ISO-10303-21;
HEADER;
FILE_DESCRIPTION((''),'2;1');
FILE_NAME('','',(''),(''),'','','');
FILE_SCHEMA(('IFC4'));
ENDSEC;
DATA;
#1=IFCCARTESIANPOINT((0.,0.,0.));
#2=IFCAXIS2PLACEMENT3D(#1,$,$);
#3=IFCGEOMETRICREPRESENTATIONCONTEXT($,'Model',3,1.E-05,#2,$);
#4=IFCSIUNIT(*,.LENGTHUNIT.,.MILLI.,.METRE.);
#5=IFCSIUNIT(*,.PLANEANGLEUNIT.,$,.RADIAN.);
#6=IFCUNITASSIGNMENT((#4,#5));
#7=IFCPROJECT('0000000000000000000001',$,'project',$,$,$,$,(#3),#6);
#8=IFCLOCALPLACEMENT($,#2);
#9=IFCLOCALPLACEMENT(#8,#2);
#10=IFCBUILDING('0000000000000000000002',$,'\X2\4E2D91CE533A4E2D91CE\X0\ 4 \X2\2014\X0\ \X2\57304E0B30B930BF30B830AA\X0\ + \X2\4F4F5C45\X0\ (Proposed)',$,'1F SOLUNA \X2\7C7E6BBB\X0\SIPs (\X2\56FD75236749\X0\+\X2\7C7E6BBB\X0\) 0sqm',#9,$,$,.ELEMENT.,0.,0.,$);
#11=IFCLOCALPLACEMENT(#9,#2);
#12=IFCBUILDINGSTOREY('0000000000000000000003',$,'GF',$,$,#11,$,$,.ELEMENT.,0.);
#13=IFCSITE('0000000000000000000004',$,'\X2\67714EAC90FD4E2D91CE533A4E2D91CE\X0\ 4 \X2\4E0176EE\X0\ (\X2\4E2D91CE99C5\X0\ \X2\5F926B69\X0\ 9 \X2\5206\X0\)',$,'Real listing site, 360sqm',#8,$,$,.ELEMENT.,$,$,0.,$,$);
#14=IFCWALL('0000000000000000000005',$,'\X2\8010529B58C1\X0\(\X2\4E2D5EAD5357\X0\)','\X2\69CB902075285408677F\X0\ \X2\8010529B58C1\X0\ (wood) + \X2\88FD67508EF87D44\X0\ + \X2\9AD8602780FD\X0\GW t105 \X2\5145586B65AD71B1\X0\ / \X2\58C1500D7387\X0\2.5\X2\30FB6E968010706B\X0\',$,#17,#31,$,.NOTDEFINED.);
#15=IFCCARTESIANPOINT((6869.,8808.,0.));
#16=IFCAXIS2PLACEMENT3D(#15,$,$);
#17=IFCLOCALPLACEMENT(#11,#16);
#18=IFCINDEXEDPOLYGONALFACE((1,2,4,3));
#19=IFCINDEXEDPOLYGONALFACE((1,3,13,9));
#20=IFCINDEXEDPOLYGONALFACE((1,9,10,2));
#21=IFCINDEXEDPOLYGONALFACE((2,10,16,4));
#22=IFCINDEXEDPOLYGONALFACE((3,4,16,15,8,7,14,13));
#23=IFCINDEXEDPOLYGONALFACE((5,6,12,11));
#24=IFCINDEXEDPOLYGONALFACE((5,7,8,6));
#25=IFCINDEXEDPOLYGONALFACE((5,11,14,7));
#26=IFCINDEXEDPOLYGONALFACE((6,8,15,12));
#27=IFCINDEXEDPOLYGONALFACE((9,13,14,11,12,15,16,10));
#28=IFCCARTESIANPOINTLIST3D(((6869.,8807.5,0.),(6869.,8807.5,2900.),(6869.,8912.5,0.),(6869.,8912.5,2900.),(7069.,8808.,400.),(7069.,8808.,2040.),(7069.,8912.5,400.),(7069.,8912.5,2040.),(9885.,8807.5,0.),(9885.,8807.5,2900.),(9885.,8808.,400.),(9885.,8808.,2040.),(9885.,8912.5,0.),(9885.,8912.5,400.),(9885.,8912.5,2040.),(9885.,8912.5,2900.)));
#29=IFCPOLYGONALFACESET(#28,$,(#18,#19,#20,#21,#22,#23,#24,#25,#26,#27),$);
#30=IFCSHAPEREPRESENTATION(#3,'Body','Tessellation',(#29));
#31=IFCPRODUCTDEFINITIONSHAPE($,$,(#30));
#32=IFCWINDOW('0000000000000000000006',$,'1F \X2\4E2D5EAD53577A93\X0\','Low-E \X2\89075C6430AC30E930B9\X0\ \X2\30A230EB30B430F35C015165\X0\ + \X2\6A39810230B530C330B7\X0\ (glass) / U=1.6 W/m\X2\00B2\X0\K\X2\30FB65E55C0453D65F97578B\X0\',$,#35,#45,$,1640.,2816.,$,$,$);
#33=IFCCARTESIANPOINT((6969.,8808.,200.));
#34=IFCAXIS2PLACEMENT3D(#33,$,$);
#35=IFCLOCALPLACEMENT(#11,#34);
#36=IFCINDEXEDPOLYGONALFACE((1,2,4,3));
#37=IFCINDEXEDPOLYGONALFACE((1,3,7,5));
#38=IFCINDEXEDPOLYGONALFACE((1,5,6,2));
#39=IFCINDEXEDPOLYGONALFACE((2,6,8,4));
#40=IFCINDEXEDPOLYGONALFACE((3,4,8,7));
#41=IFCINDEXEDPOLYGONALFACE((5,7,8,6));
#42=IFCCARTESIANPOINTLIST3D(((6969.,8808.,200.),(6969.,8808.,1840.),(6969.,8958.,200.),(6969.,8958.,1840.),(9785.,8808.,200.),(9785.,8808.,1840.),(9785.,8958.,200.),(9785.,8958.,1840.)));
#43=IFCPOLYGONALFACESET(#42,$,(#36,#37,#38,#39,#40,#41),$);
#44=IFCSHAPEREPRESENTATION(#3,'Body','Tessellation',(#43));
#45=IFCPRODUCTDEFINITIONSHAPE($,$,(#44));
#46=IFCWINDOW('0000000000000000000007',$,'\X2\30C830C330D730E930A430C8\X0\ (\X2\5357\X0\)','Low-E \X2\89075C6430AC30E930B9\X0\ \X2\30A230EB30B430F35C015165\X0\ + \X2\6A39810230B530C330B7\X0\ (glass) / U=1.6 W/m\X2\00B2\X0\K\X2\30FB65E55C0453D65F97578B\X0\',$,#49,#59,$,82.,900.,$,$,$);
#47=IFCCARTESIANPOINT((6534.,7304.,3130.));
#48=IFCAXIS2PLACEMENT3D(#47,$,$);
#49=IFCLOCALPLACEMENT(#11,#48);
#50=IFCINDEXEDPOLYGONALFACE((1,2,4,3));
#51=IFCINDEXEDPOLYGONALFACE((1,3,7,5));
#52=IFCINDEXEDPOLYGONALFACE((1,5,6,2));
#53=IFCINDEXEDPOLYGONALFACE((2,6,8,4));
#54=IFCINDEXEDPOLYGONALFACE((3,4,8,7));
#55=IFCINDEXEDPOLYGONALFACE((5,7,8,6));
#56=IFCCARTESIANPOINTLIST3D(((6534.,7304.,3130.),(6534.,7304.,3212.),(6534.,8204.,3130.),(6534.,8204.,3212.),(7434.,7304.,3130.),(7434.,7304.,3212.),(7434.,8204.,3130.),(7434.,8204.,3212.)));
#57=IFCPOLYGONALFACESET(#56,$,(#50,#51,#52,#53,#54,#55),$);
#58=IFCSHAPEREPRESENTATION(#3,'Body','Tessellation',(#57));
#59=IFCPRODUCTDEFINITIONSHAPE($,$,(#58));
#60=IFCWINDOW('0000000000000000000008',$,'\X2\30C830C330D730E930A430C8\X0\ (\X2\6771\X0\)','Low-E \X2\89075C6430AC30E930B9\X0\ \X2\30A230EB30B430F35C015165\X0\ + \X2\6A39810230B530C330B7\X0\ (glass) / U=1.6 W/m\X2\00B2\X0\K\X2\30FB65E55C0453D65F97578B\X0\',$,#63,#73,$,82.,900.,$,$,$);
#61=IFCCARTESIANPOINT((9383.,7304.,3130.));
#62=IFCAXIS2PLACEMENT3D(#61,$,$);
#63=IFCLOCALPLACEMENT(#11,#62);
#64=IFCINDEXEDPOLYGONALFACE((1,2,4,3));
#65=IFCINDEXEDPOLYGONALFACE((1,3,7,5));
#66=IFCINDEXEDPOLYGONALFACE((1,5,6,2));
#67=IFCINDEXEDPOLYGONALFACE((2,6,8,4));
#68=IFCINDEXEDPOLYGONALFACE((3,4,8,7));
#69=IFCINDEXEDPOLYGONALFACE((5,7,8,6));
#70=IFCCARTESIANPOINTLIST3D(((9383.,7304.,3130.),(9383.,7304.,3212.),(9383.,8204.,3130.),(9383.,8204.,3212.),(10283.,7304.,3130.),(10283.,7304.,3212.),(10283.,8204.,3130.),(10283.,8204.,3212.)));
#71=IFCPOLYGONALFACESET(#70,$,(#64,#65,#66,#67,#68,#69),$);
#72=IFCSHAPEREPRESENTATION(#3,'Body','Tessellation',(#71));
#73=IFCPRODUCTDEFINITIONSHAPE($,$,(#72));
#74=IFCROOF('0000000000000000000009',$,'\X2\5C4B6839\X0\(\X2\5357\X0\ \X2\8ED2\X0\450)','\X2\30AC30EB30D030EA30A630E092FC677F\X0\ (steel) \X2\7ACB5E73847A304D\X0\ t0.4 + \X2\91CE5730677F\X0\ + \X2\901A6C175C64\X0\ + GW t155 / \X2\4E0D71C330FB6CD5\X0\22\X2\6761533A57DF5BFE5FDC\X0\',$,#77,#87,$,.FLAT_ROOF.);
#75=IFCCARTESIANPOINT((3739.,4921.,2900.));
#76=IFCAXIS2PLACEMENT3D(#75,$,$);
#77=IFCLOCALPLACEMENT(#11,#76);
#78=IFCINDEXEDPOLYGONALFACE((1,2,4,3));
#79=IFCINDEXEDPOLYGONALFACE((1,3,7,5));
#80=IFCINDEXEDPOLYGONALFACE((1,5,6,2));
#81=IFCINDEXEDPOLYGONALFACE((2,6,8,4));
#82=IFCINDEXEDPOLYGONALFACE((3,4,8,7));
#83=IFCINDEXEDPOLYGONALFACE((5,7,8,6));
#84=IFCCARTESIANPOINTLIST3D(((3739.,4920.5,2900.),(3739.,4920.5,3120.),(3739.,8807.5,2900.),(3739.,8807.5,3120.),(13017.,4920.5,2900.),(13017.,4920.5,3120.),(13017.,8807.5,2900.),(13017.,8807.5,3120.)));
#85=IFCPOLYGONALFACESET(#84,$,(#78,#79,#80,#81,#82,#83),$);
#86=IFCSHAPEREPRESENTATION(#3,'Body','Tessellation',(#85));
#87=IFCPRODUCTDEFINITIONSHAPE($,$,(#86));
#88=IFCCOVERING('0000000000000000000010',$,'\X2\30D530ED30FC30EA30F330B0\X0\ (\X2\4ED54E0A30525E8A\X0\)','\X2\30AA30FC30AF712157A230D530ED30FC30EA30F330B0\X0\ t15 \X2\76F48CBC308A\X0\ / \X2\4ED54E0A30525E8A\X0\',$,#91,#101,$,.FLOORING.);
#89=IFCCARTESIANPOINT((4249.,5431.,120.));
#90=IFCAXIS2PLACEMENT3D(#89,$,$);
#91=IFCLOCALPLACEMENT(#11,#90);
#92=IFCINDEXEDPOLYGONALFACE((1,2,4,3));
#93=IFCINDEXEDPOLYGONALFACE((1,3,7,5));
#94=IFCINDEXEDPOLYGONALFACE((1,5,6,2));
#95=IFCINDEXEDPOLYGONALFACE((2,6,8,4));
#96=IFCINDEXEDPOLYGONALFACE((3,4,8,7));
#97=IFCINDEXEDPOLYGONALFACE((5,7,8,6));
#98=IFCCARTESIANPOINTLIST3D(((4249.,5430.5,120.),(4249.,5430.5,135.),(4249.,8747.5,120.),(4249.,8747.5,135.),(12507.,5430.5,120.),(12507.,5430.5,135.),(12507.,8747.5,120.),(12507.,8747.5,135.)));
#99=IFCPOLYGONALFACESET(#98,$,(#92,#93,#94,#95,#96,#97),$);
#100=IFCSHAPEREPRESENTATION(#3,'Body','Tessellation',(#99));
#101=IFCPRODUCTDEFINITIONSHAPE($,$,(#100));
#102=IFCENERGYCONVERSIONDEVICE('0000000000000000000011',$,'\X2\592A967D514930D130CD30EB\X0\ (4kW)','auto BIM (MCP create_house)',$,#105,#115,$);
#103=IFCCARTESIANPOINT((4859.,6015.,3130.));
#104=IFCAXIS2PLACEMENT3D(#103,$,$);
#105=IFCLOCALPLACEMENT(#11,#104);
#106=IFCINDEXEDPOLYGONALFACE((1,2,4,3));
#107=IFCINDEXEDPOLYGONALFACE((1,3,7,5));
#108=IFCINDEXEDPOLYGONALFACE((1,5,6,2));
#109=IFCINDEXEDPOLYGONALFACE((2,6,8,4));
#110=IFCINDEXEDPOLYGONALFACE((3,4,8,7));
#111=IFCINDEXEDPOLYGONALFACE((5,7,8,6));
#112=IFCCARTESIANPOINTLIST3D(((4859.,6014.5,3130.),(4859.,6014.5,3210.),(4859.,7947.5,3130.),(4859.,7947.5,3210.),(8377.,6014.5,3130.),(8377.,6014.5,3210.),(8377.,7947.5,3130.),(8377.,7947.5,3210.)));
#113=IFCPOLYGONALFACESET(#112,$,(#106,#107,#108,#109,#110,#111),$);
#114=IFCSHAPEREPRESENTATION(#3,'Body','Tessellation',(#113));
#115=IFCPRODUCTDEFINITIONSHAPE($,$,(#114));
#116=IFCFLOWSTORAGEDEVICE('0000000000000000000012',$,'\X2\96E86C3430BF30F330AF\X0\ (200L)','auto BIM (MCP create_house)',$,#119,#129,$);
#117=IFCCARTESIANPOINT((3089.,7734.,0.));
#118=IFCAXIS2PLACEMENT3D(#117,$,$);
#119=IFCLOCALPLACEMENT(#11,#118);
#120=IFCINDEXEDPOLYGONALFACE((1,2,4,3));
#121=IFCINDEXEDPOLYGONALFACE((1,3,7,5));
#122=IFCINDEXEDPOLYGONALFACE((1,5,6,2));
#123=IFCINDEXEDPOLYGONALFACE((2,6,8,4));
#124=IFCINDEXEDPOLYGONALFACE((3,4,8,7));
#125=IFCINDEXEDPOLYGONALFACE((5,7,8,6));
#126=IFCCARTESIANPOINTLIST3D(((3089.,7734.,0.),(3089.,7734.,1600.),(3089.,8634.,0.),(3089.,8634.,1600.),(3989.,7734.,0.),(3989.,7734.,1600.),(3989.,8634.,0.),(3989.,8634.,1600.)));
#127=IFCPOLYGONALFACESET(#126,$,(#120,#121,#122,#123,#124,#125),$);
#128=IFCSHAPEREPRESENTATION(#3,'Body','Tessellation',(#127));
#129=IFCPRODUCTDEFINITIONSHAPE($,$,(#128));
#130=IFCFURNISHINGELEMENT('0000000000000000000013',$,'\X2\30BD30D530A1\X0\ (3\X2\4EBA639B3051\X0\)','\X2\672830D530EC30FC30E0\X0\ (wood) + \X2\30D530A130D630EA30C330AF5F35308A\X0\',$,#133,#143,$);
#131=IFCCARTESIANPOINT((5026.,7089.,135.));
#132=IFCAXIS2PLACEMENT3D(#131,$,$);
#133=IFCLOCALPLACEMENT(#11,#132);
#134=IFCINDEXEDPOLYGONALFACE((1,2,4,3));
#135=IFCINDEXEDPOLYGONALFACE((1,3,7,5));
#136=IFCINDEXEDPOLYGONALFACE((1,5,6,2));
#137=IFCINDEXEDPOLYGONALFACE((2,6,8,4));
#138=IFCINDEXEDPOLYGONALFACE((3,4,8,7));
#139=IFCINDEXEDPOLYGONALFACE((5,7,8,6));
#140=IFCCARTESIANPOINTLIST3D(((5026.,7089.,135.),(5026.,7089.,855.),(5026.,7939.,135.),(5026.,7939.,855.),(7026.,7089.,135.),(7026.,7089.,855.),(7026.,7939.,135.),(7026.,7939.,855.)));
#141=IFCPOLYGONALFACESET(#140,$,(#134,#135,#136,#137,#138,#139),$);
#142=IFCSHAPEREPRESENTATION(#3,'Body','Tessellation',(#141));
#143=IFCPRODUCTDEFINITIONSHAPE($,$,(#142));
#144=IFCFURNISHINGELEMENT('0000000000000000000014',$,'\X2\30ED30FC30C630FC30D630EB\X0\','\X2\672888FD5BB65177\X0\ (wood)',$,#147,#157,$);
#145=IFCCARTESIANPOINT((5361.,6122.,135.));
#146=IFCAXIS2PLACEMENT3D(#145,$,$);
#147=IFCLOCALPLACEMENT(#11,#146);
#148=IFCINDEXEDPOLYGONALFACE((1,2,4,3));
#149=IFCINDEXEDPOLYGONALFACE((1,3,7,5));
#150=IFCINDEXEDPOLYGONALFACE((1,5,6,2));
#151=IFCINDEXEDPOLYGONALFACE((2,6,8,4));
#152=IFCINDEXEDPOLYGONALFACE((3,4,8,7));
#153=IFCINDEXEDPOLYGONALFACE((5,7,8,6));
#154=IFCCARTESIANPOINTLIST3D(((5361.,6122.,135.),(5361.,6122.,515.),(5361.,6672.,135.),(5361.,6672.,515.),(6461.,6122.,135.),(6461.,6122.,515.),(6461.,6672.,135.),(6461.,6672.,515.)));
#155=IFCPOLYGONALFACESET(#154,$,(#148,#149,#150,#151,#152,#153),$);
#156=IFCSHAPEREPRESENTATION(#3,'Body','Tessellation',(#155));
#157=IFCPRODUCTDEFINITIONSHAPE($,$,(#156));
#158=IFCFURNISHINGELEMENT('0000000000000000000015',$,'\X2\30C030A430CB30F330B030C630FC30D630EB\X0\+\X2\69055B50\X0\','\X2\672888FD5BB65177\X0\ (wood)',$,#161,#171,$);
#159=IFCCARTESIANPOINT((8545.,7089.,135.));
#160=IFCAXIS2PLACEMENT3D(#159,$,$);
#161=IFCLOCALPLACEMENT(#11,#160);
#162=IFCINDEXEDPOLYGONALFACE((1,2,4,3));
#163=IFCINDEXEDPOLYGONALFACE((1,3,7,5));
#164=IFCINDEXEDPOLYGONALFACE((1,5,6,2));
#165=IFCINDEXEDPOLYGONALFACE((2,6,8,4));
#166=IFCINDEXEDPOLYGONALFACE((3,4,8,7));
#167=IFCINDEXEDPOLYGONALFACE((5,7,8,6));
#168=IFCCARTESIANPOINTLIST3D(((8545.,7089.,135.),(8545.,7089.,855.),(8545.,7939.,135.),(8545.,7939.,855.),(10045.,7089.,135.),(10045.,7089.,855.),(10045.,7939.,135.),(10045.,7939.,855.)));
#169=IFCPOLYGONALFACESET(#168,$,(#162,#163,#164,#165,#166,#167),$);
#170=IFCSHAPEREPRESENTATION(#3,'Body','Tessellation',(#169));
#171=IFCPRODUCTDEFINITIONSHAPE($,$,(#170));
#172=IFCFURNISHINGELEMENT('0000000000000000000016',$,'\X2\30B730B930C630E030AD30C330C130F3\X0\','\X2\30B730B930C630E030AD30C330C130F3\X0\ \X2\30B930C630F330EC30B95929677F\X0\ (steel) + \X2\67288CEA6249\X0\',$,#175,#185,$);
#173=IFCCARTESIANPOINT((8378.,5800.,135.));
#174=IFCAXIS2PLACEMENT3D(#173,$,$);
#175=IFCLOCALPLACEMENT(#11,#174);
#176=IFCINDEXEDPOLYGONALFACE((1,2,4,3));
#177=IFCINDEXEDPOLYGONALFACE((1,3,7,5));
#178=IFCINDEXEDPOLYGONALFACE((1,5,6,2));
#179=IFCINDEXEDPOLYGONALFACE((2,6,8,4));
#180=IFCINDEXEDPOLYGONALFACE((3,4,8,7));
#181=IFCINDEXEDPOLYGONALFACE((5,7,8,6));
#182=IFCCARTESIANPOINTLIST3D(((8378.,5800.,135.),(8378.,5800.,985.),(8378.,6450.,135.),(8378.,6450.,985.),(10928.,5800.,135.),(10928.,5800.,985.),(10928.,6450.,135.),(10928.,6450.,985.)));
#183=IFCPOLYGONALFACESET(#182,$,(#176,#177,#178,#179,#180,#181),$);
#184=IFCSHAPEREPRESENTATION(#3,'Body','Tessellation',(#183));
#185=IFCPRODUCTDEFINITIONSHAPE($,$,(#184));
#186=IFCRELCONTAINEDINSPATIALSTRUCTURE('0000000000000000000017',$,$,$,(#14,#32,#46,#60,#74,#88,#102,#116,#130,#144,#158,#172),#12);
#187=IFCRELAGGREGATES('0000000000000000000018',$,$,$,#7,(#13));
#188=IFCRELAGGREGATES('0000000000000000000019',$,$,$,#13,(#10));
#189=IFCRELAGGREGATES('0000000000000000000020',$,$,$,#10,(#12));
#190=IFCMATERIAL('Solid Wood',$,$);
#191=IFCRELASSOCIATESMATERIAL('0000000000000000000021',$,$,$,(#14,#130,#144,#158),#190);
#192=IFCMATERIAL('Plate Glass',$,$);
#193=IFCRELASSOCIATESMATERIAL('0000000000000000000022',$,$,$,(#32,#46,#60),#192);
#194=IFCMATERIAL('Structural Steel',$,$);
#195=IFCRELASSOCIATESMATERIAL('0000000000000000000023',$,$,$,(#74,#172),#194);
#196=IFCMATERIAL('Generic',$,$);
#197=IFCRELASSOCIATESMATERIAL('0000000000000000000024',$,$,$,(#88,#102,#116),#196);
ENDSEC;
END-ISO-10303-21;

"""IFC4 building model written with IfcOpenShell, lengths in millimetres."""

from ifc_helpers import new_model, si_unit, frame, frame_2d, origin, place, context, project, spatial, rectangle, extrude, material, element, fill, save


model = new_model("IFC4")

# Units and contexts
model_context = context("Model", 3, precision=1e-05, world=origin())
ifc_project = project(units=[si_unit("LENGTHUNIT", "METRE", prefix="MILLI"), si_unit("PLANEANGLEUNIT", "RADIAN")], contexts=[model_context])

# Site, building, storey
site_placement = place(None, origin())
site = spatial("IfcSite", under=ifc_project, at=site_placement, Name="東京都中野区中野 4 丁目 (中野駅 徒歩 9 分)", ObjectType="Real listing site, 360sqm", CompositionType="ELEMENT", RefElevation=0.0)
building_placement = place(site_placement, origin())
building = spatial("IfcBuilding", under=site, at=building_placement, Name="中野区中野 4 — 地下スタジオ + 住居 (Proposed)", ObjectType="1F SOLUNA 籾殻SIPs (国産杉+籾殻) 0sqm", CompositionType="ELEMENT", ElevationOfRefHeight=0.0, ElevationOfTerrain=0.0)
storey_placement = place(building_placement, origin())
storey = spatial("IfcBuildingStorey", under=building, at=storey_placement, Name="GF", CompositionType="ELEMENT", Elevation=0.0)

# Shared definitions
ifc_material_1 = material(Name="Solid Wood")

# Shared definitions
ifc_material_2 = material(Name="Plate Glass")

# Wall, opening, window
wall_1_placement = place(storey_placement, frame((6869.0, 8808.0, 0.0)))
wall_1 = element("IfcWall", 1, at=wall_1_placement, inside=storey, material=ifc_material_1, Name="耐力壁(中庭南)", Description="構造用合板 耐力壁 (wood) + 製材軸組 + 高性能GW t105 充填断熱 / 壁倍率2.5・準耐火", PredefinedType="NOTDEFINED", context=model_context, shape_type="SweptSolid", body=[
    extrude(rectangle(XDim=3016.0, YDim=105.0, at=frame_2d((1508.0, 52.0))), frame((6869.0, 8808.0, 0.0)), (0.0, 0.0, 1.0), 2900.0),
])
opening_1_placement = place(storey_placement, frame((6969.0, 8808.0, 200.0)))
opening_1 = element("IfcOpeningElement", 2, at=opening_1_placement, cuts=wall_1, PredefinedType="NOTDEFINED", context=model_context, shape_type="SweptSolid", body=[
    extrude(rectangle(XDim=2816.0, YDim=150.0, at=frame_2d((1408.0, 75.0))), frame((6969.0, 8808.0, 200.0)), (0.0, 0.0, 1.0), 1640.0),
])
window_1_placement = place(storey_placement, frame((6969.0, 8808.0, 200.0)))
window_1 = element("IfcWindow", 3, at=window_1_placement, inside=storey, material=ifc_material_2, Name="1F 中庭南窓", Description="Low-E 複層ガラス アルゴン封入 + 樹脂サッシ (glass) / U=1.6 W/m²K・日射取得型", OverallHeight=1640.0, OverallWidth=2816.0, context=model_context, shape_type="SweptSolid", body=[
    extrude(rectangle(XDim=2816.0, YDim=150.0, at=frame_2d((1408.0, 75.0))), frame((6969.0, 8808.0, 200.0)), (0.0, 0.0, 1.0), 1640.0),
])
fill(opening_1, window_1)

# Windows
window_2_placement = place(storey_placement, frame((6534.0, 7304.0, 3130.0)))
element("IfcWindow", 4, at=window_2_placement, inside=storey, material=ifc_material_2, Name="トップライト (南)", Description="Low-E 複層ガラス アルゴン封入 + 樹脂サッシ (glass) / U=1.6 W/m²K・日射取得型", OverallHeight=82.0, OverallWidth=900.0, context=model_context, shape_type="SweptSolid", body=[
    extrude(rectangle(XDim=900.0, YDim=900.0, at=frame_2d((450.0, 450.0))), frame((6534.0, 7304.0, 3130.0)), (0.0, 0.0, 1.0), 82.0),
])
window_3_placement = place(storey_placement, frame((9383.0, 7304.0, 3130.0)))
element("IfcWindow", 5, at=window_3_placement, inside=storey, material=ifc_material_2, Name="トップライト (東)", Description="Low-E 複層ガラス アルゴン封入 + 樹脂サッシ (glass) / U=1.6 W/m²K・日射取得型", OverallHeight=82.0, OverallWidth=900.0, context=model_context, shape_type="SweptSolid", body=[
    extrude(rectangle(XDim=900.0, YDim=900.0, at=frame_2d((450.0, 450.0))), frame((9383.0, 7304.0, 3130.0)), (0.0, 0.0, 1.0), 82.0),
])

# Roof
ifc_material_3 = material(Name="Structural Steel")
roof_placement = place(storey_placement, frame((3739.0, 4921.0, 2900.0)))
element("IfcRoof", 6, at=roof_placement, inside=storey, material=ifc_material_3, Name="屋根(南 軒450)", Description="ガルバリウム鋼板 (steel) 立平葺き t0.4 + 野地板 + 通気層 + GW t155 / 不燃・法22条区域対応", PredefinedType="FLAT_ROOF", context=model_context, shape_type="SweptSolid", body=[
    extrude(rectangle(XDim=9278.0, YDim=3887.0, at=frame_2d((4639.0, 1943.0))), frame((3739.0, 4921.0, 2900.0)), (0.0, 0.0, 1.0), 220.0),
])

# Covering
ifc_material_4 = material(Name="Generic")
covering_placement = place(storey_placement, frame((4249.0, 5431.0, 120.0)))
element("IfcCovering", 7, at=covering_placement, inside=storey, material=ifc_material_4, Name="フローリング (仕上げ床)", Description="オーク無垢フローリング t15 直貼り / 仕上げ床", PredefinedType="FLOORING", context=model_context, shape_type="SweptSolid", body=[
    extrude(rectangle(XDim=8258.0, YDim=3317.0, at=frame_2d((4129.0, 1658.0))), frame((4249.0, 5431.0, 120.0)), (0.0, 0.0, 1.0), 15.0),
])

# Energy conversion device
energy_conversion_device_placement = place(storey_placement, frame((4859.0, 6015.0, 3130.0)))
element("IfcEnergyConversionDevice", 8, at=energy_conversion_device_placement, inside=storey, material=ifc_material_4, Name="太陽光パネル (4kW)", Description="auto BIM (MCP create_house)", context=model_context, shape_type="SweptSolid", body=[
    extrude(rectangle(XDim=3518.0, YDim=1933.0, at=frame_2d((1759.0, 966.0))), frame((4859.0, 6015.0, 3130.0)), (0.0, 0.0, 1.0), 80.0),
])

# Flow storage device
flow_storage_device_placement = place(storey_placement, frame((3089.0, 7734.0, 0.0)))
element("IfcFlowStorageDevice", 9, at=flow_storage_device_placement, inside=storey, material=ifc_material_4, Name="雨水タンク (200L)", Description="auto BIM (MCP create_house)", context=model_context, shape_type="SweptSolid", body=[
    extrude(rectangle(XDim=900.0, YDim=900.0, at=frame_2d((450.0, 450.0))), frame((3089.0, 7734.0, 0.0)), (0.0, 0.0, 1.0), 1600.0),
])

# Furnishing elements
furnishing_1_placement = place(storey_placement, frame((5026.0, 7089.0, 135.0)))
element("IfcFurnishingElement", 10, at=furnishing_1_placement, inside=storey, material=ifc_material_1, Name="ソファ (3人掛け)", Description="木フレーム (wood) + ファブリック張り", context=model_context, shape_type="SweptSolid", body=[
    extrude(rectangle(XDim=2000.0, YDim=850.0, at=frame_2d((1000.0, 425.0))), frame((5026.0, 7089.0, 135.0)), (0.0, 0.0, 1.0), 720.0),
])
furnishing_2_placement = place(storey_placement, frame((5361.0, 6122.0, 135.0)))
element("IfcFurnishingElement", 11, at=furnishing_2_placement, inside=storey, material=ifc_material_1, Name="ローテーブル", Description="木製家具 (wood)", context=model_context, shape_type="SweptSolid", body=[
    extrude(rectangle(XDim=1100.0, YDim=550.0, at=frame_2d((550.0, 275.0))), frame((5361.0, 6122.0, 135.0)), (0.0, 0.0, 1.0), 380.0),
])
furnishing_3_placement = place(storey_placement, frame((8545.0, 7089.0, 135.0)))
element("IfcFurnishingElement", 12, at=furnishing_3_placement, inside=storey, material=ifc_material_1, Name="ダイニングテーブル+椅子", Description="木製家具 (wood)", context=model_context, shape_type="SweptSolid", body=[
    extrude(rectangle(XDim=1500.0, YDim=850.0, at=frame_2d((750.0, 425.0))), frame((8545.0, 7089.0, 135.0)), (0.0, 0.0, 1.0), 720.0),
])
furnishing_4_placement = place(storey_placement, frame((8378.0, 5800.0, 135.0)))
element("IfcFurnishingElement", 13, at=furnishing_4_placement, inside=storey, material=ifc_material_3, Name="システムキッチン", Description="システムキッチン ステンレス天板 (steel) + 木質扉", context=model_context, shape_type="SweptSolid", body=[
    extrude(rectangle(XDim=2550.0, YDim=650.0, at=frame_2d((1275.0, 325.0))), frame((8378.0, 5800.0, 135.0)), (0.0, 0.0, 1.0), 850.0),
])

save(model, "model.ifc")
